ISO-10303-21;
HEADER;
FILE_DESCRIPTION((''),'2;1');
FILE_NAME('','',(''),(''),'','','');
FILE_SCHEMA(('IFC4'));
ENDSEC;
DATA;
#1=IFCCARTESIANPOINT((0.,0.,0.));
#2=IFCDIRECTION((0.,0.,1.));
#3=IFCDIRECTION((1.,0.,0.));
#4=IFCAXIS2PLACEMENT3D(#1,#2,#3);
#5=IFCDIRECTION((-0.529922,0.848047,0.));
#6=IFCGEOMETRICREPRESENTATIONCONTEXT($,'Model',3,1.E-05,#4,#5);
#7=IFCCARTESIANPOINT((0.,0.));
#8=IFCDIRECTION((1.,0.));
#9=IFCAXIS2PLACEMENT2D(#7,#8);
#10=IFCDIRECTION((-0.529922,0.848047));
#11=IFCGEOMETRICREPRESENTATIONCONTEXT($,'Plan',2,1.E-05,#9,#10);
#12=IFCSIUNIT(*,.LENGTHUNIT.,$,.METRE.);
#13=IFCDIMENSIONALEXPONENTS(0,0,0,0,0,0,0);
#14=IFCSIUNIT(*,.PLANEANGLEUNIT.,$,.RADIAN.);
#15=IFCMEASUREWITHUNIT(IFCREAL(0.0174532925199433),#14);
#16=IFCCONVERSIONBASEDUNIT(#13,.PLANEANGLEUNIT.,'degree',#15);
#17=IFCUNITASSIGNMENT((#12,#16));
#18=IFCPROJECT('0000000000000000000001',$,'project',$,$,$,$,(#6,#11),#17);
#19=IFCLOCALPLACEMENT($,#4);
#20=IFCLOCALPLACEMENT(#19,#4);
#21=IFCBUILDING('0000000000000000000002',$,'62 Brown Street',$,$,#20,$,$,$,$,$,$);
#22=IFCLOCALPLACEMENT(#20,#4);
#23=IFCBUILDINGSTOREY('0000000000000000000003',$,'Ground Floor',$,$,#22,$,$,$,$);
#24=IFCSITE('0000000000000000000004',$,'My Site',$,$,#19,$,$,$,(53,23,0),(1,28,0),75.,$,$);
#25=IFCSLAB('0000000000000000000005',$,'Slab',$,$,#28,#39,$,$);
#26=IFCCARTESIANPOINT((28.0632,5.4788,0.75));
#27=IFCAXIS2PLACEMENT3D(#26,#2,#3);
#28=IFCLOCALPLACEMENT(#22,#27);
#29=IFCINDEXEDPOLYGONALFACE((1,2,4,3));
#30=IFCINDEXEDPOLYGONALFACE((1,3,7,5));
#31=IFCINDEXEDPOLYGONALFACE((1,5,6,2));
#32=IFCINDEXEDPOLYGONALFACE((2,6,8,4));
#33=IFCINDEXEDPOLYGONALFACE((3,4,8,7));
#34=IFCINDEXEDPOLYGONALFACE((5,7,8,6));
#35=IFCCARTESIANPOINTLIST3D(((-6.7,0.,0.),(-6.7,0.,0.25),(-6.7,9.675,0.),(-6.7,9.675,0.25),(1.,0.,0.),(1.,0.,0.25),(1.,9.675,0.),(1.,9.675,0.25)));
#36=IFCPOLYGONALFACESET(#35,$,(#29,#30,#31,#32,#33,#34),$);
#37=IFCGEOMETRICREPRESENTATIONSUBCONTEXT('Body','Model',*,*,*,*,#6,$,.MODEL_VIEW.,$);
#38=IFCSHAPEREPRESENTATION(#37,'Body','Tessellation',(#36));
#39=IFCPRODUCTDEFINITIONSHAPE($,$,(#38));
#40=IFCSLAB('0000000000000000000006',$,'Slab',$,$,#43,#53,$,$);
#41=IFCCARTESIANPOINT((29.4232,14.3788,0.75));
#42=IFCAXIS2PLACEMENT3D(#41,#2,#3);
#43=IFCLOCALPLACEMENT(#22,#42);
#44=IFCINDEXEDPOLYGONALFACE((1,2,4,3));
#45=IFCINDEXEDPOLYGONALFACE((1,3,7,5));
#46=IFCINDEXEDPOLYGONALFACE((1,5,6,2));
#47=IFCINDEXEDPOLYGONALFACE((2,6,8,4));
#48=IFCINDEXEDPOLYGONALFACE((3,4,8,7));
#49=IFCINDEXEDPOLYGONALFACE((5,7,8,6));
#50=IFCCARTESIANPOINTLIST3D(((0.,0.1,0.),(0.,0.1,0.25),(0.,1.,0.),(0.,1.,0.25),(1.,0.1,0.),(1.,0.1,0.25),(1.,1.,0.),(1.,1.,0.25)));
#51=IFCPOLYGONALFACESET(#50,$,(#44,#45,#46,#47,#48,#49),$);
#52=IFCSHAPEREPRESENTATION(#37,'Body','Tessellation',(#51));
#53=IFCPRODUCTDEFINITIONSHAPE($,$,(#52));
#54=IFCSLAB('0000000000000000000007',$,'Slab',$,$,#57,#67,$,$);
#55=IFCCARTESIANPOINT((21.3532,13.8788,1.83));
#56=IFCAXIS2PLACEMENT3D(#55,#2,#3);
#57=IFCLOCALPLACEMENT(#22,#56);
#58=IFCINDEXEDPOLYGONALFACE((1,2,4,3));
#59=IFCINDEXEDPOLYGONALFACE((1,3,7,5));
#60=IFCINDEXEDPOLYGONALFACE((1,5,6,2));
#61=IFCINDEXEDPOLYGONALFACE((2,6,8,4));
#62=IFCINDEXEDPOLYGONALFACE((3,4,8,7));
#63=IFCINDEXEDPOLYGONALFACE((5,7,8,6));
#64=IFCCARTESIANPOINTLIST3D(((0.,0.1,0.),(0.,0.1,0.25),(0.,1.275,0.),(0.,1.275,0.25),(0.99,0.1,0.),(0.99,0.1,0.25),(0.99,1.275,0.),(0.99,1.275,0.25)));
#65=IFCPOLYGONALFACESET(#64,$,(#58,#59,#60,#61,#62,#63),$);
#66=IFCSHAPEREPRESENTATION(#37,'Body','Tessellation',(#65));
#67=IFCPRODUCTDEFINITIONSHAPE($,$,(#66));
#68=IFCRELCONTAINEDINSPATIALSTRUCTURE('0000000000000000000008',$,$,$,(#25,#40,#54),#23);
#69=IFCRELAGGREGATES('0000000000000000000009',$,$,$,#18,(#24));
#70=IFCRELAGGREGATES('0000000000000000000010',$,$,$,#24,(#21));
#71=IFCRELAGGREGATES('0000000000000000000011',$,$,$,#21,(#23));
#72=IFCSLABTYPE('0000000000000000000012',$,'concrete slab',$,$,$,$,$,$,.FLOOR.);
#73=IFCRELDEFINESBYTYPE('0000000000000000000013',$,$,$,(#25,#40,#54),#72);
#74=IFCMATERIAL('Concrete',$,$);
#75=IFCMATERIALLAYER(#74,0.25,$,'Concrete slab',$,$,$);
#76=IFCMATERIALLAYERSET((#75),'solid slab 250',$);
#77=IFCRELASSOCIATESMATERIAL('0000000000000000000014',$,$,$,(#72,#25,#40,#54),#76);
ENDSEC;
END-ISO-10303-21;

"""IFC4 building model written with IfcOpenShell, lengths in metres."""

from ifc_helpers import new_model, entity, si_unit, converted_unit, direction, frame, origin_with_axes, origin_2d_with_axis, place, context, subcontext, project, spatial, line, indexed_curve, outline, extrude, material, layer, layer_set, layer_usage, type_object, element, save


model = new_model("IFC4")

# Units and contexts
model_context = context("Model", 3, precision=1e-05, world=origin_with_axes(), true_north=direction((-0.529922, 0.848047, 0.0)))
plan_context = context("Plan", 2, precision=1e-05, world=origin_2d_with_axis(), true_north=direction((-0.529922, 0.848047)))
body_context_1 = subcontext(model_context, "Body", "Model", "MODEL_VIEW")
ifc_project = project(units=[si_unit("LENGTHUNIT", "METRE"), converted_unit("PLANEANGLEUNIT", "degree", entity("IfcReal", 0.0174532925199433), si_unit("PLANEANGLEUNIT", "RADIAN"), dimensions=[0, 0, 0, 0, 0, 0, 0])], contexts=[model_context, plan_context])

# Site, building, storey
site_placement = place(None, origin_with_axes())
site = spatial("IfcSite", under=ifc_project, at=site_placement, Name="My Site", RefLatitude=(53, 23, 0), RefLongitude=(1, 28, 0), RefElevation=75.0)
building_placement = place(site_placement, origin_with_axes())
building = spatial("IfcBuilding", under=site, at=building_placement, Name="62 Brown Street")
storey_placement = place(building_placement, origin_with_axes())
storey = spatial("IfcBuildingStorey", under=building, at=storey_placement, Name="Ground Floor")

# Shared definitions
ifc_material_1 = material(Name="Concrete")

# Slabs
ifc_layer_1 = layer(ifc_material_1, 0.25, Name="Concrete slab")
ifc_layer_set_1 = layer_set([ifc_layer_1], Name="solid slab 250")
slab_type = type_object("IfcSlabType", Name="concrete slab", PredefinedType="FLOOR", material=ifc_layer_set_1)
ifc_layer_usage_1 = layer_usage(ifc_layer_set_1, "AXIS3", "POSITIVE", 0.0)
slab_1_placement = place(storey_placement, frame((28.0632, 5.4788, 0.75), z_axis=(0.0, 0.0, 1.0), x_axis=(1.0, 0.0, 0.0)))
element("IfcSlab", 1, at=slab_1_placement, inside=storey, type_object=slab_type, material=ifc_layer_usage_1, Name="Slab", context=body_context_1, shape_type="SweptSolid", body=[
    extrude(outline(indexed_curve([(1.0, 9.675), (-6.7, 9.675), (-6.7, 0.0), (1.0, 0.0)], segments=[line(3, 2), line(2, 1), line(1, 4), line(4, 3)], self_intersect=False)), None, (0.0, 0.0, 1.0), 0.25),
])
ifc_layer_usage_2 = layer_usage(ifc_layer_set_1, "AXIS3", "POSITIVE", 0.0)
slab_2_placement = place(storey_placement, frame((29.4232, 14.3788, 0.75), z_axis=(0.0, 0.0, 1.0), x_axis=(1.0, 0.0, 0.0)))
element("IfcSlab", 2, at=slab_2_placement, inside=storey, type_object=slab_type, material=ifc_layer_usage_2, Name="Slab", context=body_context_1, shape_type="SweptSolid", body=[
    extrude(outline(indexed_curve([(1.0, 1.0), (1.0, 0.1), (0.0, 0.1), (0.0, 1.0)], segments=[line(3, 2), line(2, 1), line(1, 4), line(4, 3)], self_intersect=False)), None, (0.0, 0.0, 1.0), 0.25),
])
ifc_layer_usage_3 = layer_usage(ifc_layer_set_1, "AXIS3", "POSITIVE", 0.0)
slab_3_placement = place(storey_placement, frame((21.3532, 13.8788, 1.83), z_axis=(0.0, 0.0, 1.0), x_axis=(1.0, 0.0, 0.0)))
element("IfcSlab", 3, at=slab_3_placement, inside=storey, type_object=slab_type, material=ifc_layer_usage_3, Name="Slab", context=body_context_1, shape_type="SweptSolid", body=[
    extrude(outline(indexed_curve([(0.99, 1.275), (0.99, 0.1), (0.0, 0.1), (0.0, 1.275)], segments=[line(3, 2), line(2, 1), line(1, 4), line(4, 3)], self_intersect=False)), None, (0.0, 0.0, 1.0), 0.25),
])

save(model, "model.ifc")
